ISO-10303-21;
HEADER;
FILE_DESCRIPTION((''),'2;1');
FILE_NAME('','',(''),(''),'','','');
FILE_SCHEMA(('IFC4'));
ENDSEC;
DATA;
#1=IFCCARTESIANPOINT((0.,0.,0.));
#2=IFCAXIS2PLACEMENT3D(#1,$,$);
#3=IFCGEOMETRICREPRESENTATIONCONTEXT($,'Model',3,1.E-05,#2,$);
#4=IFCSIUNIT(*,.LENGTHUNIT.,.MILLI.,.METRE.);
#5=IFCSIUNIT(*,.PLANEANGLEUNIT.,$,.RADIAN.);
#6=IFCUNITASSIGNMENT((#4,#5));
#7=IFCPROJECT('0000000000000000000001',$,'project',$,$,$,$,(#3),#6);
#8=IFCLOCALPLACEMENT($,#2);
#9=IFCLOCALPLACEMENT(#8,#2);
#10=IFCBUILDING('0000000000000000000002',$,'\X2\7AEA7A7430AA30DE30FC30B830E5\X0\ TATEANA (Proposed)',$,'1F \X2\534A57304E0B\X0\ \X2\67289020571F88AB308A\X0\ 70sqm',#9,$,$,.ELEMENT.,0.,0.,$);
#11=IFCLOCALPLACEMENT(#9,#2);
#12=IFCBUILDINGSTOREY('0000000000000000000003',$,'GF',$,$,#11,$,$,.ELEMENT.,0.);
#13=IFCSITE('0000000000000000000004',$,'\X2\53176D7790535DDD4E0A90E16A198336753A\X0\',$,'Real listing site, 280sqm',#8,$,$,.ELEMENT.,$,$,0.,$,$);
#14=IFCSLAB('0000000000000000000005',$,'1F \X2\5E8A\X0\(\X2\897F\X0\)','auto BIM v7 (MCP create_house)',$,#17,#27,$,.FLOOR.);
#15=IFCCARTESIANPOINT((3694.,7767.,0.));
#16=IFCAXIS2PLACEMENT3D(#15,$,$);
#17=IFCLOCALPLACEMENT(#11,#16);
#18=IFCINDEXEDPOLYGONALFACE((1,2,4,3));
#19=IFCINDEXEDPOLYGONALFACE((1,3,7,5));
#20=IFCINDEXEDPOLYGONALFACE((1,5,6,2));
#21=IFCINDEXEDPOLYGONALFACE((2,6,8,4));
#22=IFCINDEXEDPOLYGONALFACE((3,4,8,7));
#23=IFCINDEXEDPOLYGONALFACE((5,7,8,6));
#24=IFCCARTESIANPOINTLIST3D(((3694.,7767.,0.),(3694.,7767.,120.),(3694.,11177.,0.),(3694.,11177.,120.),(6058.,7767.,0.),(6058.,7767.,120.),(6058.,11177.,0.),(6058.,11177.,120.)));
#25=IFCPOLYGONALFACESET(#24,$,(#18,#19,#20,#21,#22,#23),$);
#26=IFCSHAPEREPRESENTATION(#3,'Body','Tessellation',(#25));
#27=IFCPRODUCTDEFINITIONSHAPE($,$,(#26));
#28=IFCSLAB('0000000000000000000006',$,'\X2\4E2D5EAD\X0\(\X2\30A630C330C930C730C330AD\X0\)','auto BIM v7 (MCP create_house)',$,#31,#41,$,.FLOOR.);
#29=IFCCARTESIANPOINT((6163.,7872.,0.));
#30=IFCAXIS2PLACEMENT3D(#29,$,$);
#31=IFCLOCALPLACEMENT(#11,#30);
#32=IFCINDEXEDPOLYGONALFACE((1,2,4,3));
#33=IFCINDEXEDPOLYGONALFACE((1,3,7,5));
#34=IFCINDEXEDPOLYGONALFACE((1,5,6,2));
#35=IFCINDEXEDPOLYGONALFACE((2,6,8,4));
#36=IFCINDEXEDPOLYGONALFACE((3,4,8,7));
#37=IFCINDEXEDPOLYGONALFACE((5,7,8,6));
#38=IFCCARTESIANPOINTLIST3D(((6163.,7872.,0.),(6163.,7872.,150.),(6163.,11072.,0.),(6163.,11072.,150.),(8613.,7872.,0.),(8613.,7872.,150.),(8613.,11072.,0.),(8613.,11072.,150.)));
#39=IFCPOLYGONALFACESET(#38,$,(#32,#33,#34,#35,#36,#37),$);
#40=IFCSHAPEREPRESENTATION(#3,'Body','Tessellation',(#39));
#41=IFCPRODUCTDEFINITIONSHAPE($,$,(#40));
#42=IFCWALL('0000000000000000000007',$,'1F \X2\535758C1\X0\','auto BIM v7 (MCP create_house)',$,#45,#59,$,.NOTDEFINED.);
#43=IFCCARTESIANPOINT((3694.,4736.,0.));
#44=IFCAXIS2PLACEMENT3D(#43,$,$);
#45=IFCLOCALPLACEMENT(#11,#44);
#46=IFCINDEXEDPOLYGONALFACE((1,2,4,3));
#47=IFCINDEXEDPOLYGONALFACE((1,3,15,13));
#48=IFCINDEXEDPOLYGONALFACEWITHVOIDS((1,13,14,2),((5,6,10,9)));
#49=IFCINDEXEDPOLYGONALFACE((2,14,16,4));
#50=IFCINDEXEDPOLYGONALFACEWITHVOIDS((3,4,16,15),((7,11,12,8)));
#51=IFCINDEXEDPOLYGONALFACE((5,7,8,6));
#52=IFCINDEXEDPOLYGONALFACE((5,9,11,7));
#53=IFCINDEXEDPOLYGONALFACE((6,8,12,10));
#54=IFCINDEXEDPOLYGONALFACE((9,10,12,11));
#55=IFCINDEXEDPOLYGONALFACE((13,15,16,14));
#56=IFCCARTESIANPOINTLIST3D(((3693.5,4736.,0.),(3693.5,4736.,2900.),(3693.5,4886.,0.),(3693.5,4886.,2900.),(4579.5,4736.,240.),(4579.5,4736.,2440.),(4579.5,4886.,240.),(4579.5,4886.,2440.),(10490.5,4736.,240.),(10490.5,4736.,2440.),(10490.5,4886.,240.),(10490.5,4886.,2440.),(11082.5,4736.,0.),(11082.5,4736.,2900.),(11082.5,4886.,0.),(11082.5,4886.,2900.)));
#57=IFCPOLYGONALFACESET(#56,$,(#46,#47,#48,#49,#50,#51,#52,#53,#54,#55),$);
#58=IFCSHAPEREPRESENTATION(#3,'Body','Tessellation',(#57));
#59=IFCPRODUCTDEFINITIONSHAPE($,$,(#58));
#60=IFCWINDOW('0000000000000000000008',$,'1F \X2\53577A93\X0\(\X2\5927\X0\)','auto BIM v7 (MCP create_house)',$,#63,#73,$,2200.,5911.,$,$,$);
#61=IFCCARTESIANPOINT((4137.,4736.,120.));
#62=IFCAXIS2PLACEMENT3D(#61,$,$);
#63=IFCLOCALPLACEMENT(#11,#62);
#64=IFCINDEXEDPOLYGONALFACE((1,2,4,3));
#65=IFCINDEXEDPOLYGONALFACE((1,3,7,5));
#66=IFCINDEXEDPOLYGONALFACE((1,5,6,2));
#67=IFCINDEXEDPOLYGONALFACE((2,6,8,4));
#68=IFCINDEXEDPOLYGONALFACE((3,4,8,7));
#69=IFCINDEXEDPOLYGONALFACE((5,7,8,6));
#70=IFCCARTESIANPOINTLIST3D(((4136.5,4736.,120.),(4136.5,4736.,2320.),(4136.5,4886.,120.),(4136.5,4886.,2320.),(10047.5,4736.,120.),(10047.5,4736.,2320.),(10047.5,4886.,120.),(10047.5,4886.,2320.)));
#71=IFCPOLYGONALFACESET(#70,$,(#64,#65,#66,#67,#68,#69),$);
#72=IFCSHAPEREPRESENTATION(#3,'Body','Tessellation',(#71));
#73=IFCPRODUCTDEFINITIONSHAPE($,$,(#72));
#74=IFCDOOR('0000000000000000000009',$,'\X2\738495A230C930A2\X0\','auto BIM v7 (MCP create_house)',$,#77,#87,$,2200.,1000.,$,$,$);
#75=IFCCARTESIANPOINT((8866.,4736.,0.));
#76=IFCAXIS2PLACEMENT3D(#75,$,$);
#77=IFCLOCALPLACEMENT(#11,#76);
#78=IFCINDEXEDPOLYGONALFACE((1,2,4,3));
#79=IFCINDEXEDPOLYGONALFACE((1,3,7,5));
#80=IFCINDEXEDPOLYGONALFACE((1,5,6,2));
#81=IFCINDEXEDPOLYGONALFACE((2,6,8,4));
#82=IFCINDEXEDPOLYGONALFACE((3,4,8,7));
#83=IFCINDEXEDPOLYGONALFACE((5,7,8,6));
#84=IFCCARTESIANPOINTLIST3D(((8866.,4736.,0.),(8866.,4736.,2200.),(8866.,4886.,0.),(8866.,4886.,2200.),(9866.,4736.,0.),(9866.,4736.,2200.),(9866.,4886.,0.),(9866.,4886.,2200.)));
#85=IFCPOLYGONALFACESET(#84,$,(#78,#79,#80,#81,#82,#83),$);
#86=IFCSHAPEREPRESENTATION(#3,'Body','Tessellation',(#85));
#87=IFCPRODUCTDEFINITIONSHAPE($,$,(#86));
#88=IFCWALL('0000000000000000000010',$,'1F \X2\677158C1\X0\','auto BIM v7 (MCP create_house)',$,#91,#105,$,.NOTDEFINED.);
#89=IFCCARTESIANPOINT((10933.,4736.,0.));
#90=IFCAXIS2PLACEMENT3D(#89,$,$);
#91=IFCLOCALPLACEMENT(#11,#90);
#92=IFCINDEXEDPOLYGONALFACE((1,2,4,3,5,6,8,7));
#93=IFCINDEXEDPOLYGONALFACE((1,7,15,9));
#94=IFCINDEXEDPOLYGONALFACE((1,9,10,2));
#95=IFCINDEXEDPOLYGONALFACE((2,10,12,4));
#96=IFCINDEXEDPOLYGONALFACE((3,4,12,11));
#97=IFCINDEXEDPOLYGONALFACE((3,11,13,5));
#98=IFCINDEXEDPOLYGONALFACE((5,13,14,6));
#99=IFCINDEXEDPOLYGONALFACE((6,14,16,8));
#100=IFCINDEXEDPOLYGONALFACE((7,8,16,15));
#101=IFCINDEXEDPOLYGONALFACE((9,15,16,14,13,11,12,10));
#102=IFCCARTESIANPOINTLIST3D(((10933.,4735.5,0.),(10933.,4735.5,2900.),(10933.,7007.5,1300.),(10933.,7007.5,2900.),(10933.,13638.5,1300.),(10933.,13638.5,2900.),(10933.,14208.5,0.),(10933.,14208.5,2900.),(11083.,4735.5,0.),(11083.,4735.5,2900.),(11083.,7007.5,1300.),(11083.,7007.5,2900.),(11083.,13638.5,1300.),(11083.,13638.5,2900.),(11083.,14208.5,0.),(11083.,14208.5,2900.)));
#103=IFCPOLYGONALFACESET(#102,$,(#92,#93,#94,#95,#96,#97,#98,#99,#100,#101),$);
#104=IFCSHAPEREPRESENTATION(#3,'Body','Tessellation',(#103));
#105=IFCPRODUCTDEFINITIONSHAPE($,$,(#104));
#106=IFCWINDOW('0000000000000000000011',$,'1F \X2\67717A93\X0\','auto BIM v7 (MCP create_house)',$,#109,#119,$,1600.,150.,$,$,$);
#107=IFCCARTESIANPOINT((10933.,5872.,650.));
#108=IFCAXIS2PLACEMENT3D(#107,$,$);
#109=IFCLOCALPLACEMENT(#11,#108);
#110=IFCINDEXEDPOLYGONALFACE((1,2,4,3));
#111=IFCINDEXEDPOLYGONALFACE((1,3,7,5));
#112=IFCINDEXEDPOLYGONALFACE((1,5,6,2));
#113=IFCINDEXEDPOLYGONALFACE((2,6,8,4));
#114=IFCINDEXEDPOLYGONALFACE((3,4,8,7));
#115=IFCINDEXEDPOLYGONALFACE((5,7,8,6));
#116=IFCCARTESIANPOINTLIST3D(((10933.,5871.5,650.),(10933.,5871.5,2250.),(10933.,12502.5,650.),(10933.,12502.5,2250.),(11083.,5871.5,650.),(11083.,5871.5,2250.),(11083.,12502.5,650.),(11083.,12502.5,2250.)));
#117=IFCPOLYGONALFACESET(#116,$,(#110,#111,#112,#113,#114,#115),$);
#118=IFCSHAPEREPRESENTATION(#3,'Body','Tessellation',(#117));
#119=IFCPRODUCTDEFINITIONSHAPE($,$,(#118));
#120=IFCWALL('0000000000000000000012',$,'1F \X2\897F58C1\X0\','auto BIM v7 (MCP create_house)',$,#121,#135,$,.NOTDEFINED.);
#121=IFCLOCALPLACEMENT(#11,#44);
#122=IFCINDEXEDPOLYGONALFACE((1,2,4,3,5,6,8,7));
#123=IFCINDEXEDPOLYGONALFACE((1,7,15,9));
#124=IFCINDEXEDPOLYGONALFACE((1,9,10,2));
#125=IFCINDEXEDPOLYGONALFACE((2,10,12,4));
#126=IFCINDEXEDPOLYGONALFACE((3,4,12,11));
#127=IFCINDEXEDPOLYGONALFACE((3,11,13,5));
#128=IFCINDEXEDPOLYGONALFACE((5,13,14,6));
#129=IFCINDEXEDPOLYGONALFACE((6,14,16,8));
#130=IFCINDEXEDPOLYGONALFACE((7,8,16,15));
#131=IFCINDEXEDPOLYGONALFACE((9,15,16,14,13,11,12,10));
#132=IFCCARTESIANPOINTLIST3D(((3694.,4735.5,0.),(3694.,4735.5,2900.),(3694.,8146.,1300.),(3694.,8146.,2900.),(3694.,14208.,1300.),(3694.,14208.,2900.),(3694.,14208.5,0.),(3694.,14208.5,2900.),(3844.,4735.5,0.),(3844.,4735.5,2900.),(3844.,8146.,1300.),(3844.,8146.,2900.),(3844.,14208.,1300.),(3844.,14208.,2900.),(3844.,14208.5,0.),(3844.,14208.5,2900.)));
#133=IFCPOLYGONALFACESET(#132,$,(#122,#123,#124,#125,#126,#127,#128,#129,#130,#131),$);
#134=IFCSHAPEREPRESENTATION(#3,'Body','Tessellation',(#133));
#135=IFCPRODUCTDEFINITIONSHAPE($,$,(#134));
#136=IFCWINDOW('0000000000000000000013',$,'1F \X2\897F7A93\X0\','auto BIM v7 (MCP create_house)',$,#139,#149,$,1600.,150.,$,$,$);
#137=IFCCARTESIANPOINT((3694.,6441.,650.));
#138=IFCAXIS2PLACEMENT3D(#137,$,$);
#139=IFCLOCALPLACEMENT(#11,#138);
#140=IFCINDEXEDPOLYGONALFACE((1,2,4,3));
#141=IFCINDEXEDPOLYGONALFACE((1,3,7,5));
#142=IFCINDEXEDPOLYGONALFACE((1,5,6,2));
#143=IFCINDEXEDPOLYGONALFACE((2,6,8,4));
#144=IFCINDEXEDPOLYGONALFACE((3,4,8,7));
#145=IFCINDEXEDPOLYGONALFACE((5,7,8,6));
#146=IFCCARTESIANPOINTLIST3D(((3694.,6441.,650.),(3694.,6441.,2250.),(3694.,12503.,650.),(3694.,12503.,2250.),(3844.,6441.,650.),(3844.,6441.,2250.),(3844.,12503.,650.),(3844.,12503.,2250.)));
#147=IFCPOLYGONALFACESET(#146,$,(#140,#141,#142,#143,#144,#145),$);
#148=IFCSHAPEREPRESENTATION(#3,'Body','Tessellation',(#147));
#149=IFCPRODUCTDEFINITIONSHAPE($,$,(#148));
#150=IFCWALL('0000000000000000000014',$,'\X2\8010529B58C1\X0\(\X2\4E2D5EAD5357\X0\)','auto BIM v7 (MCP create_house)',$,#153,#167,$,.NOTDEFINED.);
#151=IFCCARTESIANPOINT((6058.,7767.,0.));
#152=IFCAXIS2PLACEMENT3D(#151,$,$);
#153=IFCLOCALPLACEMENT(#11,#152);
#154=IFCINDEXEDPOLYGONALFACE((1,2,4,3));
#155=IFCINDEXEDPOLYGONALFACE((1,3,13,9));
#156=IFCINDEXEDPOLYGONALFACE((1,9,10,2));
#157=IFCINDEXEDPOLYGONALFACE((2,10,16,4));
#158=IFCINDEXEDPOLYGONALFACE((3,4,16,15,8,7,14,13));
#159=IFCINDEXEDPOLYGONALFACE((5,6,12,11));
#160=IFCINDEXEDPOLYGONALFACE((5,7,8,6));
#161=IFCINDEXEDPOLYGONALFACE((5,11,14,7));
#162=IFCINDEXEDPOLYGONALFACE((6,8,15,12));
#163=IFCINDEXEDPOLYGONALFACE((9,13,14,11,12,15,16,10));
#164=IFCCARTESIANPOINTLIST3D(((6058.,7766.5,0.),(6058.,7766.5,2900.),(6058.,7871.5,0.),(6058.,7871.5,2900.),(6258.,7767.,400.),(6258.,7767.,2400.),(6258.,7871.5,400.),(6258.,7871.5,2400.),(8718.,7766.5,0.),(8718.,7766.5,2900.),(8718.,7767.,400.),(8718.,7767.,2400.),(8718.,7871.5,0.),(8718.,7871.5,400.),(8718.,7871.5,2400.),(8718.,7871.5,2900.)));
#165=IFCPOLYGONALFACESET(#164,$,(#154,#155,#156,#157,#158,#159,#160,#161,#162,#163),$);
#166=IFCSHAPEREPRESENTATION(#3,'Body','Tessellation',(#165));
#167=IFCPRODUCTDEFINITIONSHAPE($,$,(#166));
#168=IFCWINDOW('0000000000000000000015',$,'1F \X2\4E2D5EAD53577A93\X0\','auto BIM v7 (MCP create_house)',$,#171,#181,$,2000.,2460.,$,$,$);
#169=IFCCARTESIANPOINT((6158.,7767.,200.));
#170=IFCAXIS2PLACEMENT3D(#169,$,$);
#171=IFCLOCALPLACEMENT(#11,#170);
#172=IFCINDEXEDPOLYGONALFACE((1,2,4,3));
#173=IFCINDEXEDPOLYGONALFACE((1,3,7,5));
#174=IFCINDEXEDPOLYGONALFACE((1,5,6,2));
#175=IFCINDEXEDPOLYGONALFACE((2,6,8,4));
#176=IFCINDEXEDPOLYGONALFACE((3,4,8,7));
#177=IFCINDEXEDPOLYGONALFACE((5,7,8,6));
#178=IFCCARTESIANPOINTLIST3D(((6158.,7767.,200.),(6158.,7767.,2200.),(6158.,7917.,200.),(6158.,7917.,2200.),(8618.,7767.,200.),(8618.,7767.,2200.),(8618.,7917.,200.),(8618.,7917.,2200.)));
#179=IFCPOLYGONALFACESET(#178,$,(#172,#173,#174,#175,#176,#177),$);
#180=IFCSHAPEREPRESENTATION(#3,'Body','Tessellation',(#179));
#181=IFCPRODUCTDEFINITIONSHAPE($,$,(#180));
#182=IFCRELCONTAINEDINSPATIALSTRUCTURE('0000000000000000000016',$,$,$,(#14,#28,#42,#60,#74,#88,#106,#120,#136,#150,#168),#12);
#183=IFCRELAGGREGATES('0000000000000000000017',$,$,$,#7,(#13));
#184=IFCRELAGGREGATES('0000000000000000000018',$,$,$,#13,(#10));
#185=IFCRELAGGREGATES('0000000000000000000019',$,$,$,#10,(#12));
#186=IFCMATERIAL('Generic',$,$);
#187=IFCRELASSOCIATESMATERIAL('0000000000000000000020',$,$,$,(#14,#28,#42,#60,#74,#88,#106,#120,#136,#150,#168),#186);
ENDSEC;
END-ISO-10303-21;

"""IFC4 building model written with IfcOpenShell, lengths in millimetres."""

from ifc_helpers import new_model, si_unit, frame, frame_2d, origin, place, context, project, spatial, rectangle, extrude, material, element, fill, save


model = new_model("IFC4")

# Units and contexts
model_context = context("Model", 3, precision=1e-05, world=origin())
ifc_project = project(units=[si_unit("LENGTHUNIT", "METRE", prefix="MILLI"), si_unit("PLANEANGLEUNIT", "RADIAN")], contexts=[model_context])

# Site, building, storey
site_placement = place(None, origin())
site = spatial("IfcSite", under=ifc_project, at=site_placement, Name="北海道川上郡標茶町", ObjectType="Real listing site, 280sqm", CompositionType="ELEMENT", RefElevation=0.0)
building_placement = place(site_placement, origin())
building = spatial("IfcBuilding", under=site, at=building_placement, Name="竪穴オマージュ TATEANA (Proposed)", ObjectType="1F 半地下 木造土被り 70sqm", CompositionType="ELEMENT", ElevationOfRefHeight=0.0, ElevationOfTerrain=0.0)
storey_placement = place(building_placement, origin())
storey = spatial("IfcBuildingStorey", under=building, at=storey_placement, Name="GF", CompositionType="ELEMENT", Elevation=0.0)

# Slabs
ifc_material = material(Name="Generic")
slab_1_placement = place(storey_placement, frame((3694.0, 7767.0, 0.0)))
element("IfcSlab", 1, at=slab_1_placement, inside=storey, material=ifc_material, Name="1F 床(西)", Description="auto BIM v7 (MCP create_house)", PredefinedType="FLOOR", context=model_context, shape_type="SweptSolid", body=[
    extrude(rectangle(XDim=2364.0, YDim=3410.0, at=frame_2d((1182.0, 1705.0))), frame((3694.0, 7767.0, 0.0)), (0.0, 0.0, 1.0), 120.0),
])
slab_2_placement = place(storey_placement, frame((6163.0, 7872.0, 0.0)))
element("IfcSlab", 2, at=slab_2_placement, inside=storey, material=ifc_material, Name="中庭(ウッドデッキ)", Description="auto BIM v7 (MCP create_house)", PredefinedType="FLOOR", context=model_context, shape_type="SweptSolid", body=[
    extrude(rectangle(XDim=2450.0, YDim=3200.0, at=frame_2d((1225.0, 1600.0))), frame((6163.0, 7872.0, 0.0)), (0.0, 0.0, 1.0), 150.0),
])

# Wall, openings, window, door
wall_1_placement = place(storey_placement, frame((3694.0, 4736.0, 0.0)))
wall_1 = element("IfcWall", 3, at=wall_1_placement, inside=storey, material=ifc_material, Name="1F 南壁", Description="auto BIM v7 (MCP create_house)", PredefinedType="NOTDEFINED", context=model_context, shape_type="SweptSolid", body=[
    extrude(rectangle(XDim=7389.0, YDim=150.0, at=frame_2d((3694.0, 75.0))), frame((3694.0, 4736.0, 0.0)), (0.0, 0.0, 1.0), 2900.0),
])
opening_1_placement = place(storey_placement, frame((4137.0, 4736.0, 120.0)))
opening_1 = element("IfcOpeningElement", 4, at=opening_1_placement, cuts=wall_1, PredefinedType="NOTDEFINED", context=model_context, shape_type="SweptSolid", body=[
    extrude(rectangle(XDim=5911.0, YDim=150.0, at=frame_2d((2955.0, 75.0))), frame((4137.0, 4736.0, 120.0)), (0.0, 0.0, 1.0), 2200.0),
])
opening_2_placement = place(storey_placement, frame((8866.0, 4736.0, 0.0)))
opening_2 = element("IfcOpeningElement", 5, at=opening_2_placement, cuts=wall_1, PredefinedType="NOTDEFINED", context=model_context, shape_type="SweptSolid", body=[
    extrude(rectangle(XDim=1000.0, YDim=150.0, at=frame_2d((500.0, 75.0))), frame((8866.0, 4736.0, 0.0)), (0.0, 0.0, 1.0), 2200.0),
])
window_1_placement = place(storey_placement, frame((4137.0, 4736.0, 120.0)))
window_1 = element("IfcWindow", 6, at=window_1_placement, inside=storey, material=ifc_material, Name="1F 南窓(大)", Description="auto BIM v7 (MCP create_house)", OverallHeight=2200.0, OverallWidth=5911.0, context=model_context, shape_type="SweptSolid", body=[
    extrude(rectangle(XDim=5911.0, YDim=150.0, at=frame_2d((2955.0, 75.0))), frame((4137.0, 4736.0, 120.0)), (0.0, 0.0, 1.0), 2200.0),
])
fill(opening_1, window_1)
door_placement = place(storey_placement, frame((8866.0, 4736.0, 0.0)))
door = element("IfcDoor", 7, at=door_placement, inside=storey, material=ifc_material, Name="玄関ドア", Description="auto BIM v7 (MCP create_house)", OverallHeight=2200.0, OverallWidth=1000.0, context=model_context, shape_type="SweptSolid", body=[
    extrude(rectangle(XDim=1000.0, YDim=150.0, at=frame_2d((500.0, 75.0))), frame((8866.0, 4736.0, 0.0)), (0.0, 0.0, 1.0), 2200.0),
])
fill(opening_2, door)

# Walls, openings, windows
wall_2_placement = place(storey_placement, frame((10933.0, 4736.0, 0.0)))
wall_2 = element("IfcWall", 8, at=wall_2_placement, inside=storey, material=ifc_material, Name="1F 東壁", Description="auto BIM v7 (MCP create_house)", PredefinedType="NOTDEFINED", context=model_context, shape_type="SweptSolid", body=[
    extrude(rectangle(XDim=150.0, YDim=9473.0, at=frame_2d((75.0, 4736.0))), frame((10933.0, 4736.0, 0.0)), (0.0, 0.0, 1.0), 2900.0),
])
opening_3_placement = place(storey_placement, frame((10933.0, 5872.0, 650.0)))
opening_3 = element("IfcOpeningElement", 9, at=opening_3_placement, cuts=wall_2, PredefinedType="NOTDEFINED", context=model_context, shape_type="SweptSolid", body=[
    extrude(rectangle(XDim=150.0, YDim=6631.0, at=frame_2d((75.0, 3315.0))), frame((10933.0, 5872.0, 650.0)), (0.0, 0.0, 1.0), 1600.0),
])
window_2_placement = place(storey_placement, frame((10933.0, 5872.0, 650.0)))
window_2 = element("IfcWindow", 10, at=window_2_placement, inside=storey, material=ifc_material, Name="1F 東窓", Description="auto BIM v7 (MCP create_house)", OverallHeight=1600.0, OverallWidth=150.0, context=model_context, shape_type="SweptSolid", body=[
    extrude(rectangle(XDim=150.0, YDim=6631.0, at=frame_2d((75.0, 3315.0))), frame((10933.0, 5872.0, 650.0)), (0.0, 0.0, 1.0), 1600.0),
])
fill(opening_3, window_2)
wall_3_placement = place(storey_placement, frame((3694.0, 4736.0, 0.0)))
wall_3 = element("IfcWall", 11, at=wall_3_placement, inside=storey, material=ifc_material, Name="1F 西壁", Description="auto BIM v7 (MCP create_house)", PredefinedType="NOTDEFINED", context=model_context, shape_type="SweptSolid", body=[
    extrude(rectangle(XDim=150.0, YDim=9473.0, at=frame_2d((75.0, 4736.0))), frame((3694.0, 4736.0, 0.0)), (0.0, 0.0, 1.0), 2900.0),
])
opening_4_placement = place(storey_placement, frame((3694.0, 6441.0, 650.0)))
opening_4 = element("IfcOpeningElement", 12, at=opening_4_placement, cuts=wall_3, PredefinedType="NOTDEFINED", context=model_context, shape_type="SweptSolid", body=[
    extrude(rectangle(XDim=150.0, YDim=6062.0, at=frame_2d((75.0, 3031.0))), frame((3694.0, 6441.0, 650.0)), (0.0, 0.0, 1.0), 1600.0),
])
window_3_placement = place(storey_placement, frame((3694.0, 6441.0, 650.0)))
window_3 = element("IfcWindow", 13, at=window_3_placement, inside=storey, material=ifc_material, Name="1F 西窓", Description="auto BIM v7 (MCP create_house)", OverallHeight=1600.0, OverallWidth=150.0, context=model_context, shape_type="SweptSolid", body=[
    extrude(rectangle(XDim=150.0, YDim=6062.0, at=frame_2d((75.0, 3031.0))), frame((3694.0, 6441.0, 650.0)), (0.0, 0.0, 1.0), 1600.0),
])
fill(opening_4, window_3)
wall_4_placement = place(storey_placement, frame((6058.0, 7767.0, 0.0)))
wall_4 = element("IfcWall", 14, at=wall_4_placement, inside=storey, material=ifc_material, Name="耐力壁(中庭南)", Description="auto BIM v7 (MCP create_house)", PredefinedType="NOTDEFINED", context=model_context, shape_type="SweptSolid", body=[
    extrude(rectangle(XDim=2660.0, YDim=105.0, at=frame_2d((1330.0, 52.0))), frame((6058.0, 7767.0, 0.0)), (0.0, 0.0, 1.0), 2900.0),
])
opening_5_placement = place(storey_placement, frame((6158.0, 7767.0, 200.0)))
opening_5 = element("IfcOpeningElement", 15, at=opening_5_placement, cuts=wall_4, PredefinedType="NOTDEFINED", context=model_context, shape_type="SweptSolid", body=[
    extrude(rectangle(XDim=2460.0, YDim=150.0, at=frame_2d((1230.0, 75.0))), frame((6158.0, 7767.0, 200.0)), (0.0, 0.0, 1.0), 2000.0),
])
window_4_placement = place(storey_placement, frame((6158.0, 7767.0, 200.0)))
window_4 = element("IfcWindow", 16, at=window_4_placement, inside=storey, material=ifc_material, Name="1F 中庭南窓", Description="auto BIM v7 (MCP create_house)", OverallHeight=2000.0, OverallWidth=2460.0, context=model_context, shape_type="SweptSolid", body=[
    extrude(rectangle(XDim=2460.0, YDim=150.0, at=frame_2d((1230.0, 75.0))), frame((6158.0, 7767.0, 200.0)), (0.0, 0.0, 1.0), 2000.0),
])
fill(opening_5, window_4)

save(model, "model.ifc")
